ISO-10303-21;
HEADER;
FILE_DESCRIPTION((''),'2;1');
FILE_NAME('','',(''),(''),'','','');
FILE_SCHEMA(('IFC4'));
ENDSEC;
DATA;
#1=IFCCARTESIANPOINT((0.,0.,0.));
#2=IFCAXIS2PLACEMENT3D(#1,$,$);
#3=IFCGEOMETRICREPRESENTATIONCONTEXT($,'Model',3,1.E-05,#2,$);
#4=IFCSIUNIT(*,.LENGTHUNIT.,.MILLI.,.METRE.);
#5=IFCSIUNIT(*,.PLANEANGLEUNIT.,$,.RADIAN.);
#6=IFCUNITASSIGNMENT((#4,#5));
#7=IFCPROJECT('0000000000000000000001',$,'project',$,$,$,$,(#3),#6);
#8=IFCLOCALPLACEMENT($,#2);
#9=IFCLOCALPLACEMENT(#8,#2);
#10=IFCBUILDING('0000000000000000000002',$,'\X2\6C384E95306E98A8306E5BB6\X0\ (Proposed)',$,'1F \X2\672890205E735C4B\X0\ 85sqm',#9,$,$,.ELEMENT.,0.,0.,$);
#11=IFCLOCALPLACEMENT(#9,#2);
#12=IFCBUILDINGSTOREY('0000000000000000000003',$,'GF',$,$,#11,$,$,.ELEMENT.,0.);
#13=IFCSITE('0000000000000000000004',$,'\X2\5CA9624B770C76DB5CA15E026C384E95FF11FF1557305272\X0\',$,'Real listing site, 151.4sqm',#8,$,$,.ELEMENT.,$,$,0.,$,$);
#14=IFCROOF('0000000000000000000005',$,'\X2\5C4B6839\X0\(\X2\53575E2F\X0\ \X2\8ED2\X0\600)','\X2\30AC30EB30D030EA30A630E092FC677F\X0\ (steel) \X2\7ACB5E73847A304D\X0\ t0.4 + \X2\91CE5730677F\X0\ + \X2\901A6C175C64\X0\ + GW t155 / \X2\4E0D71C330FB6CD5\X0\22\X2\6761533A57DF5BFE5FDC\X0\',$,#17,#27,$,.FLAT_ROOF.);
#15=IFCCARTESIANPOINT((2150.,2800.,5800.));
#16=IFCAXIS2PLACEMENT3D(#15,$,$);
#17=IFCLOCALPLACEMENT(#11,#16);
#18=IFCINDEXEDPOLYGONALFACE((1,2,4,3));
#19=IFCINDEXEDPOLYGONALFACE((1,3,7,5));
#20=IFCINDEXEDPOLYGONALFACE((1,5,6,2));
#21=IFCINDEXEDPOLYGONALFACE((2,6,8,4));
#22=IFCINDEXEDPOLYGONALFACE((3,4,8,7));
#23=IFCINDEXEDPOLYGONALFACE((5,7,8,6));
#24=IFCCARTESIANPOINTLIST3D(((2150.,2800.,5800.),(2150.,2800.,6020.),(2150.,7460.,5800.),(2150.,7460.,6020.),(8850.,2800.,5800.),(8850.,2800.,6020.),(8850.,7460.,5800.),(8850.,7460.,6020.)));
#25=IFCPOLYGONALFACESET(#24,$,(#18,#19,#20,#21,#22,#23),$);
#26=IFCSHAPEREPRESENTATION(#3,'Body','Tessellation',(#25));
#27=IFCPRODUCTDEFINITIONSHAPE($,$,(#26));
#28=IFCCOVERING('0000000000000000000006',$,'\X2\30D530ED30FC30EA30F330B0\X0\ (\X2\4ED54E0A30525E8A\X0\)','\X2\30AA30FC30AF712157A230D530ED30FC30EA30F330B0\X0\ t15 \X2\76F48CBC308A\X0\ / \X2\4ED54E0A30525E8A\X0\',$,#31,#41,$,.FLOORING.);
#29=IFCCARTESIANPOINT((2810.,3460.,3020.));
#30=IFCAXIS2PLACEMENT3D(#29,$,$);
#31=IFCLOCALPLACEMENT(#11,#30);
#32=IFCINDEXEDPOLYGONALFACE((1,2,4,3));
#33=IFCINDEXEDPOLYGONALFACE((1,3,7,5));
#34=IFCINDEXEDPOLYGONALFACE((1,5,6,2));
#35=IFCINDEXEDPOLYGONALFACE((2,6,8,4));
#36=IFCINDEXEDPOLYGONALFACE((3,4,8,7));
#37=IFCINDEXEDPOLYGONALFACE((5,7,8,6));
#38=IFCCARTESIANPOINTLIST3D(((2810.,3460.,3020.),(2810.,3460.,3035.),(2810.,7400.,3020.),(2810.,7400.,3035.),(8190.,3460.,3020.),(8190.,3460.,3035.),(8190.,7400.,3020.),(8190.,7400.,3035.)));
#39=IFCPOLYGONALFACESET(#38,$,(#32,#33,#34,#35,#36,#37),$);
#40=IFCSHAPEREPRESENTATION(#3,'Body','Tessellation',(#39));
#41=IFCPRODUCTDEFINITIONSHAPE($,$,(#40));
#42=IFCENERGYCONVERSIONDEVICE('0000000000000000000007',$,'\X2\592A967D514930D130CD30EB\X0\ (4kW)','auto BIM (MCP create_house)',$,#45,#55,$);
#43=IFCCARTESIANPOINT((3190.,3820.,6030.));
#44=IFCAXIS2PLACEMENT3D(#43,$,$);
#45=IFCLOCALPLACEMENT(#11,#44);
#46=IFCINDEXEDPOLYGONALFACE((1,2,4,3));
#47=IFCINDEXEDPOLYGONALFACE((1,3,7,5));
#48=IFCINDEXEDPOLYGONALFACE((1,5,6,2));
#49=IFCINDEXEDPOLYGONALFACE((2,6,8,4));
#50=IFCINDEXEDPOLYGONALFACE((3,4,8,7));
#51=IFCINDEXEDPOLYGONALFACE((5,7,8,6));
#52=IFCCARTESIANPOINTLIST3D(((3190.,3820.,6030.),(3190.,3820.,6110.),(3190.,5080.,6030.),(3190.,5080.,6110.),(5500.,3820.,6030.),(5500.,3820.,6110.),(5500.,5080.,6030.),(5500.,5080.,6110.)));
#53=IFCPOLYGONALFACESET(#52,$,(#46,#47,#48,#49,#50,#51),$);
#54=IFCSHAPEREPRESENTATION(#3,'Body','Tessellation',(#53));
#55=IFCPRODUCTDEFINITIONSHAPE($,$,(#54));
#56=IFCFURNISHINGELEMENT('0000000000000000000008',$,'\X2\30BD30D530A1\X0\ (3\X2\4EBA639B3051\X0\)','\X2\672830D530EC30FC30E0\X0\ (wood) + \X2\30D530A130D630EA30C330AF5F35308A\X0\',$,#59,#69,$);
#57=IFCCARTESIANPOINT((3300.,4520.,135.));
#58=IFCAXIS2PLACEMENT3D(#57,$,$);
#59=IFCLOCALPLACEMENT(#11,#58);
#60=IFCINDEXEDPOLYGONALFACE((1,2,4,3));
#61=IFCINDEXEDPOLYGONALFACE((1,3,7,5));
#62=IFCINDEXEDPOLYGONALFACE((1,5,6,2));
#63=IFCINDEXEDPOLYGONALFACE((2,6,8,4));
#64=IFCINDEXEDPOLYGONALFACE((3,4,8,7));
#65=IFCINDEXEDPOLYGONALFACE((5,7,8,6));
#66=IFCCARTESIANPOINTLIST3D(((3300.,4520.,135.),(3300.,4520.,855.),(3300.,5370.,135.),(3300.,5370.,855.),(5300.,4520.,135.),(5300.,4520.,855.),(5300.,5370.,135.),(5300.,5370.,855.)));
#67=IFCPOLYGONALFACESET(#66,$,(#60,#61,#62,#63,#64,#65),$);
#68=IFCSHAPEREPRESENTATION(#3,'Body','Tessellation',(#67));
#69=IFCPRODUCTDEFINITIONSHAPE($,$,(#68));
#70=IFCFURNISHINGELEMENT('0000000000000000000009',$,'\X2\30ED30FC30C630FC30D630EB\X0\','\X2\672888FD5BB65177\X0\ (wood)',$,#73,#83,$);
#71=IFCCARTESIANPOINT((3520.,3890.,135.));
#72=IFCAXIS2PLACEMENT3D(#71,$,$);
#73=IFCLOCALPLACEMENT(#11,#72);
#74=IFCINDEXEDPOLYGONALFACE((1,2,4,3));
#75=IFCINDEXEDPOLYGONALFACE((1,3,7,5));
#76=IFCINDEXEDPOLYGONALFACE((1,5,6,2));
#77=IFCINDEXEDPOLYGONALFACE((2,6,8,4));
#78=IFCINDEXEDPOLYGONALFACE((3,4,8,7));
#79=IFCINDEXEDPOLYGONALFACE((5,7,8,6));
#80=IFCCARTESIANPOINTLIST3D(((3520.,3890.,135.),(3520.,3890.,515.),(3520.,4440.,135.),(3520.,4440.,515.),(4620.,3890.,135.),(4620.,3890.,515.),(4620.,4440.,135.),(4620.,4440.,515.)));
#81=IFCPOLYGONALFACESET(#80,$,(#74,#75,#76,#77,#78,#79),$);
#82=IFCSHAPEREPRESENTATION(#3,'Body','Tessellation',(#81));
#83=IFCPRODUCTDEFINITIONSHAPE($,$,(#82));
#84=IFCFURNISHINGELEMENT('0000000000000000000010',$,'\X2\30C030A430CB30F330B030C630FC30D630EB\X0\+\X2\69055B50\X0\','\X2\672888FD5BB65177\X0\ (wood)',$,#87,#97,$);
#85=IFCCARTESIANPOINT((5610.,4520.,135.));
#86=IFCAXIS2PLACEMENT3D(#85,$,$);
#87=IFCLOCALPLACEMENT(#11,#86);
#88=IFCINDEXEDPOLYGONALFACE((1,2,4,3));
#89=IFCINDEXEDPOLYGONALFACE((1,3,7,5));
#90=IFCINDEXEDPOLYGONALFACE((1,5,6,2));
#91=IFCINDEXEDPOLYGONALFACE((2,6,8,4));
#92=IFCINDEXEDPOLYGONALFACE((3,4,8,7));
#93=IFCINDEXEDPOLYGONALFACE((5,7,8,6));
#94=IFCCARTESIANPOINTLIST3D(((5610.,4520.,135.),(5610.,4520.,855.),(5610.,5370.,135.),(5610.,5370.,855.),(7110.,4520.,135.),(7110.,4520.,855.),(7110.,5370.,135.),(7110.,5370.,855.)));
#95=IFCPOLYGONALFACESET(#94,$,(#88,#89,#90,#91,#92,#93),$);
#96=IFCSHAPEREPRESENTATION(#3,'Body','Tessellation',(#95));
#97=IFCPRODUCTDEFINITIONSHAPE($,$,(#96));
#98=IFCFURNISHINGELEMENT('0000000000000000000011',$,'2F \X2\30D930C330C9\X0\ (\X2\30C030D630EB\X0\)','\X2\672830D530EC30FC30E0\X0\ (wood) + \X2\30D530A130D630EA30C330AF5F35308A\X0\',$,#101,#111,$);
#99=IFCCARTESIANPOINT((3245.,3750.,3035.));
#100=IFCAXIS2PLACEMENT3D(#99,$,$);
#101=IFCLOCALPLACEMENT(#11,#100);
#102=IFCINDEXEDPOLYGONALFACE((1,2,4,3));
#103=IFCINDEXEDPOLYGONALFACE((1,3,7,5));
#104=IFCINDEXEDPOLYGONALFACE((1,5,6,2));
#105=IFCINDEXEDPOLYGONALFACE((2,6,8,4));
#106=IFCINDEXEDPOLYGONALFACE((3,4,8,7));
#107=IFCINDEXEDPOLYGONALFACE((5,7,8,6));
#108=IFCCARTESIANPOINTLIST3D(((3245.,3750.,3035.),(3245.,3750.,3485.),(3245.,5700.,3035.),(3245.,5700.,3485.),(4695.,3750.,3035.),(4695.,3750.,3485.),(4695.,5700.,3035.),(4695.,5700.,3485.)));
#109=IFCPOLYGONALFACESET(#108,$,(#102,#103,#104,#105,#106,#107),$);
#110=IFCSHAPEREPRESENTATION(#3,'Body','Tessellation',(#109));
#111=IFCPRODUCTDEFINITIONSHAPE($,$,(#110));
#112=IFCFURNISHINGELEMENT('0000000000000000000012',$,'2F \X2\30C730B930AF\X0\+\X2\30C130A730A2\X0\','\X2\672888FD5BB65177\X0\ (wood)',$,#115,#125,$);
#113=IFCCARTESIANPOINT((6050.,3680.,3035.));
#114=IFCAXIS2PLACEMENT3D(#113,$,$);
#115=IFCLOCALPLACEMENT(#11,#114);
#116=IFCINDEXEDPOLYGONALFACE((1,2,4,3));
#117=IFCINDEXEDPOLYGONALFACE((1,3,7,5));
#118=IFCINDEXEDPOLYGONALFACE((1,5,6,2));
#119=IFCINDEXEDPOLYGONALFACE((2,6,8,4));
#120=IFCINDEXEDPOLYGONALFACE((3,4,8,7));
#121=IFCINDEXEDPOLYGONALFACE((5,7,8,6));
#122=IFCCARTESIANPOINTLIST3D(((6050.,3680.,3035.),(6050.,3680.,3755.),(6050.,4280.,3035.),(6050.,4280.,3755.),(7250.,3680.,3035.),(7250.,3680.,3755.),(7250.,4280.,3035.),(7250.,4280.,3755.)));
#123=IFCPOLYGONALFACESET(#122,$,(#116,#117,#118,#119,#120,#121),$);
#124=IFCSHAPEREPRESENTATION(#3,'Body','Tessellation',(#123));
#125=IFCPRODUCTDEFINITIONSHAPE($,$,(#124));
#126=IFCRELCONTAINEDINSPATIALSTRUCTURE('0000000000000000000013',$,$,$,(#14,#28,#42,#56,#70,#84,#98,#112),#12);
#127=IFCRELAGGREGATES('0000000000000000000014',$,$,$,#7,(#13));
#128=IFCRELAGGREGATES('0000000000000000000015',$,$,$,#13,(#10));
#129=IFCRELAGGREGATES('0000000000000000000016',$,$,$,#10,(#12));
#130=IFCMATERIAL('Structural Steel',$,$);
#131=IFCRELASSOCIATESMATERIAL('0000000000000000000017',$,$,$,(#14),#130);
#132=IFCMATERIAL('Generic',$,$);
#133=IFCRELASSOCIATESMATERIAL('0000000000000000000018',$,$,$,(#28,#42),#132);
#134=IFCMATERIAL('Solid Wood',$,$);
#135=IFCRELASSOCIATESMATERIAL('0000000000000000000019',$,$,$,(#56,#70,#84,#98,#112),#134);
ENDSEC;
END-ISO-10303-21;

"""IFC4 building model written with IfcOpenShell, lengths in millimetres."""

from ifc_helpers import new_model, si_unit, frame, frame_2d, origin, place, context, project, spatial, rectangle, extrude, material, element, save


model = new_model("IFC4")

# Units and contexts
model_context = context("Model", 3, precision=1e-05, world=origin())
ifc_project = project(units=[si_unit("LENGTHUNIT", "METRE", prefix="MILLI"), si_unit("PLANEANGLEUNIT", "RADIAN")], contexts=[model_context])

# Site, building, storey
site_placement = place(None, origin())
site = spatial("IfcSite", under=ifc_project, at=site_placement, Name="岩手県盛岡市永井１５地割", ObjectType="Real listing site, 151.4sqm", CompositionType="ELEMENT", RefElevation=0.0)
building_placement = place(site_placement, origin())
building = spatial("IfcBuilding", under=site, at=building_placement, Name="永井の風の家 (Proposed)", ObjectType="1F 木造平屋 85sqm", CompositionType="ELEMENT", ElevationOfRefHeight=0.0, ElevationOfTerrain=0.0)
storey_placement = place(building_placement, origin())
storey = spatial("IfcBuildingStorey", under=building, at=storey_placement, Name="GF", CompositionType="ELEMENT", Elevation=0.0)

# Shared definitions
ifc_material_1 = material(Name="Solid Wood")

# Shared definitions
ifc_material_2 = material(Name="Generic")

# Roof
ifc_material_3 = material(Name="Structural Steel")
for number, where, name in (
    (1, (2150.0, 2800.0, 5800.0), "屋根(南帯 軒600)"),
):
    element("IfcRoof", number, at=place(storey_placement, frame(where)), inside=storey, material=ifc_material_3, Name=name, Description="ガルバリウム鋼板 (steel) 立平葺き t0.4 + 野地板 + 通気層 + GW t155 / 不燃・法22条区域対応", PredefinedType="FLAT_ROOF", context=model_context, shape_type="SweptSolid", body=[
        extrude(rectangle(XDim=6700.0, YDim=4660.0, at=frame_2d((3350.0, 2330.0))), frame((2150.0, 2800.0, 5800.0)), (0.0, 0.0, 1.0), 220.0),
    ])

# Covering
covering_placement = place(storey_placement, frame((2810.0, 3460.0, 3020.0)))
element("IfcCovering", 2, at=covering_placement, inside=storey, material=ifc_material_2, Name="フローリング (仕上げ床)", Description="オーク無垢フローリング t15 直貼り / 仕上げ床", PredefinedType="FLOORING", context=model_context, shape_type="SweptSolid", body=[
    extrude(rectangle(XDim=5380.0, YDim=3940.0, at=frame_2d((2690.0, 1970.0))), frame((2810.0, 3460.0, 3020.0)), (0.0, 0.0, 1.0), 15.0),
])

# Energy conversion device
energy_conversion_device_placement = place(storey_placement, frame((3190.0, 3820.0, 6030.0)))
element("IfcEnergyConversionDevice", 3, at=energy_conversion_device_placement, inside=storey, material=ifc_material_2, Name="太陽光パネル (4kW)", Description="auto BIM (MCP create_house)", context=model_context, shape_type="SweptSolid", body=[
    extrude(rectangle(XDim=2310.0, YDim=1260.0, at=frame_2d((1155.0, 630.0))), frame((3190.0, 3820.0, 6030.0)), (0.0, 0.0, 1.0), 80.0),
])

# Furnishing elements
furnishing_1_placement = place(storey_placement, frame((3300.0, 4520.0, 135.0)))
element("IfcFurnishingElement", 4, at=furnishing_1_placement, inside=storey, material=ifc_material_1, Name="ソファ (3人掛け)", Description="木フレーム (wood) + ファブリック張り", context=model_context, shape_type="SweptSolid", body=[
    extrude(rectangle(XDim=2000.0, YDim=850.0, at=frame_2d((1000.0, 425.0))), frame((3300.0, 4520.0, 135.0)), (0.0, 0.0, 1.0), 720.0),
])
furnishing_2_placement = place(storey_placement, frame((3520.0, 3890.0, 135.0)))
element("IfcFurnishingElement", 5, at=furnishing_2_placement, inside=storey, material=ifc_material_1, Name="ローテーブル", Description="木製家具 (wood)", context=model_context, shape_type="SweptSolid", body=[
    extrude(rectangle(XDim=1100.0, YDim=550.0, at=frame_2d((550.0, 275.0))), frame((3520.0, 3890.0, 135.0)), (0.0, 0.0, 1.0), 380.0),
])
furnishing_3_placement = place(storey_placement, frame((5610.0, 4520.0, 135.0)))
element("IfcFurnishingElement", 6, at=furnishing_3_placement, inside=storey, material=ifc_material_1, Name="ダイニングテーブル+椅子", Description="木製家具 (wood)", context=model_context, shape_type="SweptSolid", body=[
    extrude(rectangle(XDim=1500.0, YDim=850.0, at=frame_2d((750.0, 425.0))), frame((5610.0, 4520.0, 135.0)), (0.0, 0.0, 1.0), 720.0),
])
furnishing_4_placement = place(storey_placement, frame((3245.0, 3750.0, 3035.0)))
element("IfcFurnishingElement", 7, at=furnishing_4_placement, inside=storey, material=ifc_material_1, Name="2F ベッド (ダブル)", Description="木フレーム (wood) + ファブリック張り", context=model_context, shape_type="SweptSolid", body=[
    extrude(rectangle(XDim=1450.0, YDim=1950.0, at=frame_2d((725.0, 975.0))), frame((3245.0, 3750.0, 3035.0)), (0.0, 0.0, 1.0), 450.0),
])
furnishing_5_placement = place(storey_placement, frame((6050.0, 3680.0, 3035.0)))
element("IfcFurnishingElement", 8, at=furnishing_5_placement, inside=storey, material=ifc_material_1, Name="2F デスク+チェア", Description="木製家具 (wood)", context=model_context, shape_type="SweptSolid", body=[
    extrude(rectangle(XDim=1200.0, YDim=600.0, at=frame_2d((600.0, 300.0))), frame((6050.0, 3680.0, 3035.0)), (0.0, 0.0, 1.0), 720.0),
])

save(model, "model.ifc")
